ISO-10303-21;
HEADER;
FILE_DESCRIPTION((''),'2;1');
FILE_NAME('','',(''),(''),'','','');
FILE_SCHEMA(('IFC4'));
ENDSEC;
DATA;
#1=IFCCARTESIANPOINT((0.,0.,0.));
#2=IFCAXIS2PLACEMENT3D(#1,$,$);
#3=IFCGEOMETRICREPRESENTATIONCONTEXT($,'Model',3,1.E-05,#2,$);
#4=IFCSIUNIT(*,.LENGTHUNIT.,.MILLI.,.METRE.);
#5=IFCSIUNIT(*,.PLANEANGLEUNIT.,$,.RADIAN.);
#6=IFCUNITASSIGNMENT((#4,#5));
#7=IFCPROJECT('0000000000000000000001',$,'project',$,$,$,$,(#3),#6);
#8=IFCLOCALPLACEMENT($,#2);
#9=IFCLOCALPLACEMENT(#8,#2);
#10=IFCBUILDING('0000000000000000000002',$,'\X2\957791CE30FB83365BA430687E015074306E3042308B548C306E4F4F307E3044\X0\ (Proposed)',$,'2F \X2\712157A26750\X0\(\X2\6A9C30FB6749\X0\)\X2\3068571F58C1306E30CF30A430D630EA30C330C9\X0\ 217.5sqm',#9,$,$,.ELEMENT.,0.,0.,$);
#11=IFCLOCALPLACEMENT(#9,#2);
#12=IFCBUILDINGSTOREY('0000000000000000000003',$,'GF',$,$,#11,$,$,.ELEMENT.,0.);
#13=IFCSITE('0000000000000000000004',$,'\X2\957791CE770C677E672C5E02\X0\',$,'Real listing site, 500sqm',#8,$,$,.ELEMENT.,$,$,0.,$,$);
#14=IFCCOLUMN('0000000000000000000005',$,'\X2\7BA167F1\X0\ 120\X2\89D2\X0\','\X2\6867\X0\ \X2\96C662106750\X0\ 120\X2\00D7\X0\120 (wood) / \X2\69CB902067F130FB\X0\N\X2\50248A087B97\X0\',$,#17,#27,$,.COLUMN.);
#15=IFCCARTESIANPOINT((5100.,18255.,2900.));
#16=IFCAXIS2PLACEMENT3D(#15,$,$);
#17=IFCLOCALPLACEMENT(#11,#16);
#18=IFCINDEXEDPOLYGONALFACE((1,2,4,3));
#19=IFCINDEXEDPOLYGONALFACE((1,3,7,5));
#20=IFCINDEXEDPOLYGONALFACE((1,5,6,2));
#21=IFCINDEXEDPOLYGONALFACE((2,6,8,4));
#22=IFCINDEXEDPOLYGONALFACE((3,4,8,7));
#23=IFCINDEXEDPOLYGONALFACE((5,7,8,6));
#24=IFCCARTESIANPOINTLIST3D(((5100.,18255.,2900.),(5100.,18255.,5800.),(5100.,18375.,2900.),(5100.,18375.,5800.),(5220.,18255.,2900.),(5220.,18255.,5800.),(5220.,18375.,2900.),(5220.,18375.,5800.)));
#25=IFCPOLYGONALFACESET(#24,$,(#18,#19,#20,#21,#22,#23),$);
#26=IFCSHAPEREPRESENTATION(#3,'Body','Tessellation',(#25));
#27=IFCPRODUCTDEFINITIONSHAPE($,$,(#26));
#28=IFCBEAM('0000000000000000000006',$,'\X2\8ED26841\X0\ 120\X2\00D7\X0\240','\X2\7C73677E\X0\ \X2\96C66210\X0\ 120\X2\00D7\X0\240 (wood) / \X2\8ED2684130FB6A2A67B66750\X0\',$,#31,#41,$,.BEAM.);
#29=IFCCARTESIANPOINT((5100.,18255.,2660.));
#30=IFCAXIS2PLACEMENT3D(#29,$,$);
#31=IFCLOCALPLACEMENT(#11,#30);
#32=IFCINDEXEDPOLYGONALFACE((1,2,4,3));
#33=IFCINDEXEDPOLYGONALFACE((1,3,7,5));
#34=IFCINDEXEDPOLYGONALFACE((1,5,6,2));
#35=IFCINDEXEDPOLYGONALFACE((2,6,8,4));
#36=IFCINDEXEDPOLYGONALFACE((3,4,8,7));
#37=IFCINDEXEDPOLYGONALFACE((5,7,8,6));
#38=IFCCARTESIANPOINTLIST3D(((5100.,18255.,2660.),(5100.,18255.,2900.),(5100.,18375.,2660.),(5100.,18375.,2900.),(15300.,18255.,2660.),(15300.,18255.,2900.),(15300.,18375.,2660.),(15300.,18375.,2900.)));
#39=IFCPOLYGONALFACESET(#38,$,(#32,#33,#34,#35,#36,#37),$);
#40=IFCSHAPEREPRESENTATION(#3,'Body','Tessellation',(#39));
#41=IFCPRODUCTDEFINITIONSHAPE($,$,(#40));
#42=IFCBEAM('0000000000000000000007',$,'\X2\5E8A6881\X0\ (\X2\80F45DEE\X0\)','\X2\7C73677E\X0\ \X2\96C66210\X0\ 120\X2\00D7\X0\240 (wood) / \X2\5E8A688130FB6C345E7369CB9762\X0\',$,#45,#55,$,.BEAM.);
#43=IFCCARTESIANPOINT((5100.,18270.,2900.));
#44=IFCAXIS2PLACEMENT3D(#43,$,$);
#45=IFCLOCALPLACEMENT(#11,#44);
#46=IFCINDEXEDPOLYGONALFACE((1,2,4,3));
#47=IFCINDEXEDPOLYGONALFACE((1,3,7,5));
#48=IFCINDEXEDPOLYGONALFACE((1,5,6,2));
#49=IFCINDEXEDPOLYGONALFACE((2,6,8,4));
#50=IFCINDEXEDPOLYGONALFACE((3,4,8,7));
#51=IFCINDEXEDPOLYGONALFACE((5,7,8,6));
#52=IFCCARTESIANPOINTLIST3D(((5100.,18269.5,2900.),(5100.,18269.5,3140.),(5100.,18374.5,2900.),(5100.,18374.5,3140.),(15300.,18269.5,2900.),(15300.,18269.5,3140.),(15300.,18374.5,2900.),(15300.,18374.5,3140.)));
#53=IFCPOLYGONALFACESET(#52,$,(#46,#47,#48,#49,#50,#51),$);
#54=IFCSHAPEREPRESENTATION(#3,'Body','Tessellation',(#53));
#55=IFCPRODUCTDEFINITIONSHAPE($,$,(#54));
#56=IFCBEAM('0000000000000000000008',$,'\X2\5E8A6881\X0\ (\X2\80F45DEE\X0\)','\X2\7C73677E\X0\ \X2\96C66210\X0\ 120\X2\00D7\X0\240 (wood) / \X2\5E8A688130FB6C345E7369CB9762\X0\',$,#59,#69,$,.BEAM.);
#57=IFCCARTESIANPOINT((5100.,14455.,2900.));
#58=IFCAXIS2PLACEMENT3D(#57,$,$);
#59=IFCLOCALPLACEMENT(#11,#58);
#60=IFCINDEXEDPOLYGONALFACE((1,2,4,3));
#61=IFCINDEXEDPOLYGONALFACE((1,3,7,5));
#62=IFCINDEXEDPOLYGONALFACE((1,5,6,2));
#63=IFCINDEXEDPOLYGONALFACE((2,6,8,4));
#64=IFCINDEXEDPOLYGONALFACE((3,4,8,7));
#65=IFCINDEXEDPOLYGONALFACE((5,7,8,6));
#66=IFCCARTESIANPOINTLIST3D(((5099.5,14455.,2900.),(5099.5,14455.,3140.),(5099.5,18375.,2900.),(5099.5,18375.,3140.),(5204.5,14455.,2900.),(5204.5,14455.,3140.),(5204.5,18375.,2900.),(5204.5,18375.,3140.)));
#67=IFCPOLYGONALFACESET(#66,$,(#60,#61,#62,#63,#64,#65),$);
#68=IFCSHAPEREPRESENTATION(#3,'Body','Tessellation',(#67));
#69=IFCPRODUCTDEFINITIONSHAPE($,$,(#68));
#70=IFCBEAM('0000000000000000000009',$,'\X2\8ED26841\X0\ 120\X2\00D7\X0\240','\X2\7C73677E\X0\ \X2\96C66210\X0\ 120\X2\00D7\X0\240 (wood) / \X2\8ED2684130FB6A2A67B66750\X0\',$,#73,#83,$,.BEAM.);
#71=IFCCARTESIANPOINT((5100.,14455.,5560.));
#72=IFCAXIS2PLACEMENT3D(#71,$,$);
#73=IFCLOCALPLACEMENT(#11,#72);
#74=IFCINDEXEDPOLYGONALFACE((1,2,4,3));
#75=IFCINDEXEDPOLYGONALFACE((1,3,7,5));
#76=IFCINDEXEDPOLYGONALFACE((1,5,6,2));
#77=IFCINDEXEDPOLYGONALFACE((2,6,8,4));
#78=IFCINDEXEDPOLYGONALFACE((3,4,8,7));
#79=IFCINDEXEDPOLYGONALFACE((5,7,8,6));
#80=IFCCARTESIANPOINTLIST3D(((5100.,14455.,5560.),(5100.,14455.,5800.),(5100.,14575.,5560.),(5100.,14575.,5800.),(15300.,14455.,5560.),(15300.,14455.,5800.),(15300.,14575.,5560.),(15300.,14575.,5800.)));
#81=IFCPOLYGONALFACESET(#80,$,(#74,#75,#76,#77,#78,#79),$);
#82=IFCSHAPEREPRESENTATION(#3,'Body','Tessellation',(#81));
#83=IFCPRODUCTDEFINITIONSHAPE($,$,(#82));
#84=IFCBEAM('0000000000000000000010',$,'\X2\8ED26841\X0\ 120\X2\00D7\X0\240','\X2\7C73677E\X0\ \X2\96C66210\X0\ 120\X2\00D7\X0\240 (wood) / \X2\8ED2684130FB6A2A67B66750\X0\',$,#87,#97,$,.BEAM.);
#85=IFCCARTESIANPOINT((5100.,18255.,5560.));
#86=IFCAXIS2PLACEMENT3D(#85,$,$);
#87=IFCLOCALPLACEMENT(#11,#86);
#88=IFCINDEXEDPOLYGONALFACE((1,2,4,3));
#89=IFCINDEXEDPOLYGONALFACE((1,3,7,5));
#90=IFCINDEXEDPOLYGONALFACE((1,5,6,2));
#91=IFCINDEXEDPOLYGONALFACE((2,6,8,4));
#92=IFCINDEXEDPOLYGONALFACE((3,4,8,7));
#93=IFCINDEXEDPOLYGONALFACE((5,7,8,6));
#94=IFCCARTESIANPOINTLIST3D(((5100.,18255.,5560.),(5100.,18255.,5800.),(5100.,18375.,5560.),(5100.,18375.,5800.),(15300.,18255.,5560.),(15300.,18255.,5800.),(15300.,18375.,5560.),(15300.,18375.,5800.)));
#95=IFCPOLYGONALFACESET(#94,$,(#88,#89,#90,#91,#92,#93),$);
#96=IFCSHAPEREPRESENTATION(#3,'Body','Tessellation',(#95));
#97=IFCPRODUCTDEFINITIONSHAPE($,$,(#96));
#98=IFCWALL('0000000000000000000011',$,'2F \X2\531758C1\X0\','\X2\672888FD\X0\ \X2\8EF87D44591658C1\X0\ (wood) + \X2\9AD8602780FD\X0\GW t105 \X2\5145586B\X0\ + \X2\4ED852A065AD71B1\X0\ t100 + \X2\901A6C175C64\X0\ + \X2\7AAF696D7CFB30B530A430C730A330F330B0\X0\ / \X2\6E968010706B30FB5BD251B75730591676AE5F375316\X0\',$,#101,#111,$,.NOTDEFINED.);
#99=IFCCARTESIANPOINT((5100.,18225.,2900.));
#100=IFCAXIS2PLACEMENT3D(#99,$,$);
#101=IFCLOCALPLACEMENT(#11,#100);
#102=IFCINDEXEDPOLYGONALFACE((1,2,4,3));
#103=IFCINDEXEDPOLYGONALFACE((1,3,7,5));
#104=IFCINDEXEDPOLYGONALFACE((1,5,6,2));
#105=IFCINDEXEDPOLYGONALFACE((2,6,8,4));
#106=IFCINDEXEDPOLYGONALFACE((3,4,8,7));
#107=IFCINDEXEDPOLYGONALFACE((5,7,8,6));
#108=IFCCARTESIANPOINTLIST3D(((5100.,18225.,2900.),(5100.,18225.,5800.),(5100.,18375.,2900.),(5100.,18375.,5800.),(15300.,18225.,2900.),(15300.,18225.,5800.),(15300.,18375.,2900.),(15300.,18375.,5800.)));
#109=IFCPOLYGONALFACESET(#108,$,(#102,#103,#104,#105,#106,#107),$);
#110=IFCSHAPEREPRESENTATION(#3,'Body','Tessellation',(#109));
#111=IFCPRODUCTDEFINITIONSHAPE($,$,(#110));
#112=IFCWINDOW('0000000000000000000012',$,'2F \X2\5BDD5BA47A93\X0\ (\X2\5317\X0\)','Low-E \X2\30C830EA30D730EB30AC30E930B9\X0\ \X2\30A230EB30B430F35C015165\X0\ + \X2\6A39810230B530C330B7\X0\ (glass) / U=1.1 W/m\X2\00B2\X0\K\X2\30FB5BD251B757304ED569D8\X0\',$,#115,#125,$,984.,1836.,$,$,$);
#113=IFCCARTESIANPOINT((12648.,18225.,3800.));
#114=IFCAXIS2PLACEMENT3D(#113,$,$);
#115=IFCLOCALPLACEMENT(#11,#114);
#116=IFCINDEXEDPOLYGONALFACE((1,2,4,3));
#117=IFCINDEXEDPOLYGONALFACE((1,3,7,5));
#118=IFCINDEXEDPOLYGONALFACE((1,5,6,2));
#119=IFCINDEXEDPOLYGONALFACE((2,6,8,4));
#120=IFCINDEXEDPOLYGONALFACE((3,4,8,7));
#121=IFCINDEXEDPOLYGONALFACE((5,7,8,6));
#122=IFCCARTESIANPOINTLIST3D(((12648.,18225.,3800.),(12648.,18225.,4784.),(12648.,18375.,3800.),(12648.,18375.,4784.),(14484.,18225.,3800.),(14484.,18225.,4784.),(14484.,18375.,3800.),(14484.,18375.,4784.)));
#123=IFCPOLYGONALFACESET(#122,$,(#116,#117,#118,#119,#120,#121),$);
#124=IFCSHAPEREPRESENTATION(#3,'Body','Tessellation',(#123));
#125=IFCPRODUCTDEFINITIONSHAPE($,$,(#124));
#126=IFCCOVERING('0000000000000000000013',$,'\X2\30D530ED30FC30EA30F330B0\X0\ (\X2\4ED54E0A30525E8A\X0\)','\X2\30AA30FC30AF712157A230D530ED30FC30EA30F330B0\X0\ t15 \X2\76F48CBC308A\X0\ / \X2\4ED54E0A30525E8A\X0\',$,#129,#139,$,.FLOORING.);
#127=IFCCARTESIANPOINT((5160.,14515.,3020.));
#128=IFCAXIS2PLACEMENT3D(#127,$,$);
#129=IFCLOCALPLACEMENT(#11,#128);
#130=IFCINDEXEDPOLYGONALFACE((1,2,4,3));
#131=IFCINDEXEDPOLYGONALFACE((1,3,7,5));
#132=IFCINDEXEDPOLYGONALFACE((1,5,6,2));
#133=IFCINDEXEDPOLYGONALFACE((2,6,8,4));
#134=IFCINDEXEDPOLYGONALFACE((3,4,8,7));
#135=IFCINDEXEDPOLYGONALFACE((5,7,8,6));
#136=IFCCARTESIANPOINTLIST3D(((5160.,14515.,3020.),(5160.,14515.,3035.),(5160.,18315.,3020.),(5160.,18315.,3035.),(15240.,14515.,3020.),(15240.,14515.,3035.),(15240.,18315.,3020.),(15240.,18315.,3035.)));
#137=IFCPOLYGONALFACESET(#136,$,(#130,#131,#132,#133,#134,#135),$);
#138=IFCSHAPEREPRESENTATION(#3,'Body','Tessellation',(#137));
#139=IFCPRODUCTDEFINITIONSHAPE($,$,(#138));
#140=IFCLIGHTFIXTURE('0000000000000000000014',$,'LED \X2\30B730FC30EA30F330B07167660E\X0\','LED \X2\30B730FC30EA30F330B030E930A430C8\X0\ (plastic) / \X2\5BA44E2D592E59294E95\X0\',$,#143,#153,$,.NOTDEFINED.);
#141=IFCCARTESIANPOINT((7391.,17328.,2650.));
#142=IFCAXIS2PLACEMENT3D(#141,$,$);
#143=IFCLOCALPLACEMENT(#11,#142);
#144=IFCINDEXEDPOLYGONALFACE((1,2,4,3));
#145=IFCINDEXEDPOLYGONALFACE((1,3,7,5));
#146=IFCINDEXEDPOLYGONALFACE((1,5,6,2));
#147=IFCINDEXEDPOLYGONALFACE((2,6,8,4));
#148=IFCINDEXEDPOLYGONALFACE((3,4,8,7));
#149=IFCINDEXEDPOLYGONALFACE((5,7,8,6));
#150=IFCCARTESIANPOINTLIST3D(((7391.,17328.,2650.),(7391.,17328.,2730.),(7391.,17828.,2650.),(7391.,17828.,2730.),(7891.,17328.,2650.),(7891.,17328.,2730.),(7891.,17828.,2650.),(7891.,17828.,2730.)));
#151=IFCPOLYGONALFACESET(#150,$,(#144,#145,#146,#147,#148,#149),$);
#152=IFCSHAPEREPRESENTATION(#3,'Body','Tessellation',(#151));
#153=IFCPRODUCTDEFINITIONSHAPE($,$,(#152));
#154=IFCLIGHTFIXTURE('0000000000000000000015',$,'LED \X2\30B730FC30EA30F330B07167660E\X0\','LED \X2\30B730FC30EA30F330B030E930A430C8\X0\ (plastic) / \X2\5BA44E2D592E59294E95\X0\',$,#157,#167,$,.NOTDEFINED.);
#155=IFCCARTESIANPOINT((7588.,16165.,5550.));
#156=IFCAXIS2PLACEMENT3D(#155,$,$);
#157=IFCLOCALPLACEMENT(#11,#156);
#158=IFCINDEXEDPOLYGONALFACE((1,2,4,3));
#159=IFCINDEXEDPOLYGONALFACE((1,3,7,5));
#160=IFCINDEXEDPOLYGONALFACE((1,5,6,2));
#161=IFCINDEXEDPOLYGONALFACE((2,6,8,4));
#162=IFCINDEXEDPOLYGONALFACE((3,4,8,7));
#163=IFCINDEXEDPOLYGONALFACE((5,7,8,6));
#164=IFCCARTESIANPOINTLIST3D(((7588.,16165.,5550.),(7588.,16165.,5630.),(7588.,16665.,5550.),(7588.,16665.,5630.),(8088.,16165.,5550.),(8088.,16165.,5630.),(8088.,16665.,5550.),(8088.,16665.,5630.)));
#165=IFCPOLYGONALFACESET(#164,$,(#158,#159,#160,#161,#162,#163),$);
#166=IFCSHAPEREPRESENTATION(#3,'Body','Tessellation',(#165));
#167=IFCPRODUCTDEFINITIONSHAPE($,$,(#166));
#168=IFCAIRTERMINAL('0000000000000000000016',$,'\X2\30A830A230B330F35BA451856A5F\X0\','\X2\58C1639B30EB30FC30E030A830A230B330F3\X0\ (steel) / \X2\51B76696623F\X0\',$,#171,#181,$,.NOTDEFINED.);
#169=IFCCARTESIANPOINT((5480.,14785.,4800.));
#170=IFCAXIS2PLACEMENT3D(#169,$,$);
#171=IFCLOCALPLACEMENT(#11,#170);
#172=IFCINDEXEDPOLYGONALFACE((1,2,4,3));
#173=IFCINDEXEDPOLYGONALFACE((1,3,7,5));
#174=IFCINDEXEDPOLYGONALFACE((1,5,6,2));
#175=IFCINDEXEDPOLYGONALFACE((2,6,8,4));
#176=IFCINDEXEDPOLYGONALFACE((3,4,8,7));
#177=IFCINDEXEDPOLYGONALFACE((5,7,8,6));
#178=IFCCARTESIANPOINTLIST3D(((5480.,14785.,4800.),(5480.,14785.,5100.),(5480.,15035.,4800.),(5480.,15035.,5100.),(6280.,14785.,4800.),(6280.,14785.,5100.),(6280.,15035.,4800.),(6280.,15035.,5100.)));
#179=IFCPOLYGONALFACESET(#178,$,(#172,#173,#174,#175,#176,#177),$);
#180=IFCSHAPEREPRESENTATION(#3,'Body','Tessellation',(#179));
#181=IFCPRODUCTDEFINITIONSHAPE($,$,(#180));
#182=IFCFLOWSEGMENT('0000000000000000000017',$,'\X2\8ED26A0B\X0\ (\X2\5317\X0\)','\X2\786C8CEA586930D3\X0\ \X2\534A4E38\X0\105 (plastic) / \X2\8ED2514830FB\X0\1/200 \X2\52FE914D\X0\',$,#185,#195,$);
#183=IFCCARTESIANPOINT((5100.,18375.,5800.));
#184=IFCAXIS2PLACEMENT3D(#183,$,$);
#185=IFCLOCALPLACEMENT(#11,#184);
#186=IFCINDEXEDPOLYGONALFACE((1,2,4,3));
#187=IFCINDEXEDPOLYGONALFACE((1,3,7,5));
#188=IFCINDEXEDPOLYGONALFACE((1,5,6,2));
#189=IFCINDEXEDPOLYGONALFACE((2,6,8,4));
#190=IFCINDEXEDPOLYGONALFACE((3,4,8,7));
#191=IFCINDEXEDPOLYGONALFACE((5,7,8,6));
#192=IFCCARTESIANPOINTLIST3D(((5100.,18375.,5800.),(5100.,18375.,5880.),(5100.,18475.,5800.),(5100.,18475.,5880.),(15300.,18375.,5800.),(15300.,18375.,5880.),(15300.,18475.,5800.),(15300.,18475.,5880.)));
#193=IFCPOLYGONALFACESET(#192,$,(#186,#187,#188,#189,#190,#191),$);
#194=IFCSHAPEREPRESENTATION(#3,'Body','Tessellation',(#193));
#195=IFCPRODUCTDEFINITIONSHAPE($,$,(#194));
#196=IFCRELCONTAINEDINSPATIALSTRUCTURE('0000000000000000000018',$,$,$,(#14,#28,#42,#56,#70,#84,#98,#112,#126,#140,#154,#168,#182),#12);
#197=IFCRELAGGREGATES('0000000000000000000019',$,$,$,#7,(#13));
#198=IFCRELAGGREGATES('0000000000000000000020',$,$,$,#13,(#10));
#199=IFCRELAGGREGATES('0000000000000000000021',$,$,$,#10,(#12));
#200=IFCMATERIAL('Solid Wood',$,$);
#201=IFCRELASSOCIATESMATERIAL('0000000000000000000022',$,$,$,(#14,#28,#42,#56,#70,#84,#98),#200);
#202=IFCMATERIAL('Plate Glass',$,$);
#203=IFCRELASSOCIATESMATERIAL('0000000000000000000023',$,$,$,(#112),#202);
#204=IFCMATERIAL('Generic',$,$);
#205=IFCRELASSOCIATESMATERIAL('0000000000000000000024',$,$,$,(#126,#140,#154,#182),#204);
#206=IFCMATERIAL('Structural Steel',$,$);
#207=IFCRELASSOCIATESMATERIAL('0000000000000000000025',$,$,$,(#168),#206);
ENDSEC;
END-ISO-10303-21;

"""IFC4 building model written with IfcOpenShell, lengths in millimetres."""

from ifc_helpers import new_model, si_unit, frame, frame_2d, origin, place, context, project, spatial, rectangle, extrude, material, element, fill, save


model = new_model("IFC4")

# Units and contexts
model_context = context("Model", 3, precision=1e-05, world=origin())
ifc_project = project(units=[si_unit("LENGTHUNIT", "METRE", prefix="MILLI"), si_unit("PLANEANGLEUNIT", "RADIAN")], contexts=[model_context])

# Site, building, storey
site_placement = place(None, origin())
site = spatial("IfcSite", under=ifc_project, at=site_placement, Name="長野県松本市", ObjectType="Real listing site, 500sqm", CompositionType="ELEMENT", RefElevation=0.0)
building_placement = place(site_placement, origin())
building = spatial("IfcBuilding", under=site, at=building_placement, Name="長野・茶室と縁側のある和の住まい (Proposed)", ObjectType="2F 無垢材(檜・杉)と土壁のハイブリッド 217.5sqm", CompositionType="ELEMENT", ElevationOfRefHeight=0.0, ElevationOfTerrain=0.0)
storey_placement = place(building_placement, origin())
storey = spatial("IfcBuildingStorey", under=building, at=storey_placement, Name="GF", CompositionType="ELEMENT", Elevation=0.0)

# Column
ifc_material_1 = material(Name="Solid Wood")
column_1_placement = place(storey_placement, frame((5100.0, 18255.0, 2900.0)))
element("IfcColumn", 1, at=column_1_placement, inside=storey, material=ifc_material_1, Name="管柱 120角", Description="桧 集成材 120×120 (wood) / 構造柱・N値計算", PredefinedType="COLUMN", context=model_context, shape_type="SweptSolid", body=[
    extrude(rectangle(XDim=120.0, YDim=120.0, at=frame_2d((60.0, 60.0))), frame((5100.0, 18255.0, 2900.0)), (0.0, 0.0, 1.0), 2900.0),
])

# Beams
beam_1_placement = place(storey_placement, frame((5100.0, 18255.0, 2660.0)))
element("IfcBeam", 2, at=beam_1_placement, inside=storey, material=ifc_material_1, Name="軒桁 120×240", Description="米松 集成 120×240 (wood) / 軒桁・横架材", PredefinedType="BEAM", context=model_context, shape_type="SweptSolid", body=[
    extrude(rectangle(XDim=10200.0, YDim=120.0, at=frame_2d((5100.0, 60.0))), frame((5100.0, 18255.0, 2660.0)), (0.0, 0.0, 1.0), 240.0),
])
beam_2_placement = place(storey_placement, frame((5100.0, 18270.0, 2900.0)))
element("IfcBeam", 3, at=beam_2_placement, inside=storey, material=ifc_material_1, Name="床梁 (胴差)", Description="米松 集成 120×240 (wood) / 床梁・水平構面", PredefinedType="BEAM", context=model_context, shape_type="SweptSolid", body=[
    extrude(rectangle(XDim=10200.0, YDim=105.0, at=frame_2d((5100.0, 52.0))), frame((5100.0, 18270.0, 2900.0)), (0.0, 0.0, 1.0), 240.0),
])
beam_3_placement = place(storey_placement, frame((5100.0, 14455.0, 2900.0)))
element("IfcBeam", 4, at=beam_3_placement, inside=storey, material=ifc_material_1, Name="床梁 (胴差)", Description="米松 集成 120×240 (wood) / 床梁・水平構面", PredefinedType="BEAM", context=model_context, shape_type="SweptSolid", body=[
    extrude(rectangle(XDim=105.0, YDim=3920.0, at=frame_2d((52.0, 1960.0))), frame((5100.0, 14455.0, 2900.0)), (0.0, 0.0, 1.0), 240.0),
])
beam_4_placement = place(storey_placement, frame((5100.0, 14455.0, 5560.0)))
element("IfcBeam", 5, at=beam_4_placement, inside=storey, material=ifc_material_1, Name="軒桁 120×240", Description="米松 集成 120×240 (wood) / 軒桁・横架材", PredefinedType="BEAM", context=model_context, shape_type="SweptSolid", body=[
    extrude(rectangle(XDim=10200.0, YDim=120.0, at=frame_2d((5100.0, 60.0))), frame((5100.0, 14455.0, 5560.0)), (0.0, 0.0, 1.0), 240.0),
])
beam_5_placement = place(storey_placement, frame((5100.0, 18255.0, 5560.0)))
element("IfcBeam", 6, at=beam_5_placement, inside=storey, material=ifc_material_1, Name="軒桁 120×240", Description="米松 集成 120×240 (wood) / 軒桁・横架材", PredefinedType="BEAM", context=model_context, shape_type="SweptSolid", body=[
    extrude(rectangle(XDim=10200.0, YDim=120.0, at=frame_2d((5100.0, 60.0))), frame((5100.0, 18255.0, 5560.0)), (0.0, 0.0, 1.0), 240.0),
])

# Wall, opening, window
wall_placement = place(storey_placement, frame((5100.0, 18225.0, 2900.0)))
wall = element("IfcWall", 7, at=wall_placement, inside=storey, material=ifc_material_1, Name="2F 北壁", Description="木製 軸組外壁 (wood) + 高性能GW t105 充填 + 付加断熱 t100 + 通気層 + 窯業系サイディング / 準耐火・寒冷地外皮強化", PredefinedType="NOTDEFINED", context=model_context, shape_type="SweptSolid", body=[
    extrude(rectangle(XDim=10200.0, YDim=150.0, at=frame_2d((5100.0, 75.0))), frame((5100.0, 18225.0, 2900.0)), (0.0, 0.0, 1.0), 2900.0),
])
opening_placement = place(storey_placement, frame((12648.0, 18225.0, 3800.0)))
opening = element("IfcOpeningElement", 8, at=opening_placement, cuts=wall, PredefinedType="NOTDEFINED", context=model_context, shape_type="SweptSolid", body=[
    extrude(rectangle(XDim=1836.0, YDim=150.0, at=frame_2d((918.0, 75.0))), frame((12648.0, 18225.0, 3800.0)), (0.0, 0.0, 1.0), 984.0),
])
ifc_material_2 = material(Name="Plate Glass")
window_placement = place(storey_placement, frame((12648.0, 18225.0, 3800.0)))
window = element("IfcWindow", 9, at=window_placement, inside=storey, material=ifc_material_2, Name="2F 寝室窓 (北)", Description="Low-E トリプルガラス アルゴン封入 + 樹脂サッシ (glass) / U=1.1 W/m²K・寒冷地仕様", OverallHeight=984.0, OverallWidth=1836.0, context=model_context, shape_type="SweptSolid", body=[
    extrude(rectangle(XDim=1836.0, YDim=150.0, at=frame_2d((918.0, 75.0))), frame((12648.0, 18225.0, 3800.0)), (0.0, 0.0, 1.0), 984.0),
])
fill(opening, window)

# Covering
ifc_material_3 = material(Name="Generic")
covering_placement = place(storey_placement, frame((5160.0, 14515.0, 3020.0)))
element("IfcCovering", 10, at=covering_placement, inside=storey, material=ifc_material_3, Name="フローリング (仕上げ床)", Description="オーク無垢フローリング t15 直貼り / 仕上げ床", PredefinedType="FLOORING", context=model_context, shape_type="SweptSolid", body=[
    extrude(rectangle(XDim=10080.0, YDim=3800.0, at=frame_2d((5040.0, 1900.0))), frame((5160.0, 14515.0, 3020.0)), (0.0, 0.0, 1.0), 15.0),
])

# Light fixtures
light_fixture_1_placement = place(storey_placement, frame((7391.0, 17328.0, 2650.0)))
element("IfcLightFixture", 11, at=light_fixture_1_placement, inside=storey, material=ifc_material_3, Name="LED シーリング照明", Description="LED シーリングライト (plastic) / 室中央天井", PredefinedType="NOTDEFINED", context=model_context, shape_type="SweptSolid", body=[
    extrude(rectangle(XDim=500.0, YDim=500.0, at=frame_2d((250.0, 250.0))), frame((7391.0, 17328.0, 2650.0)), (0.0, 0.0, 1.0), 80.0),
])
light_fixture_2_placement = place(storey_placement, frame((7588.0, 16165.0, 5550.0)))
element("IfcLightFixture", 12, at=light_fixture_2_placement, inside=storey, material=ifc_material_3, Name="LED シーリング照明", Description="LED シーリングライト (plastic) / 室中央天井", PredefinedType="NOTDEFINED", context=model_context, shape_type="SweptSolid", body=[
    extrude(rectangle(XDim=500.0, YDim=500.0, at=frame_2d((250.0, 250.0))), frame((7588.0, 16165.0, 5550.0)), (0.0, 0.0, 1.0), 80.0),
])

# Air terminal
ifc_material_4 = material(Name="Structural Steel")
air_terminal_placement = place(storey_placement, frame((5480.0, 14785.0, 4800.0)))
element("IfcAirTerminal", 13, at=air_terminal_placement, inside=storey, material=ifc_material_4, Name="エアコン室内機", Description="壁掛ルームエアコン (steel) / 冷暖房", PredefinedType="NOTDEFINED", context=model_context, shape_type="SweptSolid", body=[
    extrude(rectangle(XDim=800.0, YDim=250.0, at=frame_2d((400.0, 125.0))), frame((5480.0, 14785.0, 4800.0)), (0.0, 0.0, 1.0), 300.0),
])

# Flow segment
flow_segment_placement = place(storey_placement, frame((5100.0, 18375.0, 5800.0)))
element("IfcFlowSegment", 14, at=flow_segment_placement, inside=storey, material=ifc_material_3, Name="軒樋 (北)", Description="硬質塩ビ 半丸105 (plastic) / 軒先・1/200 勾配", context=model_context, shape_type="SweptSolid", body=[
    extrude(rectangle(XDim=10200.0, YDim=100.0, at=frame_2d((5100.0, 50.0))), frame((5100.0, 18375.0, 5800.0)), (0.0, 0.0, 1.0), 80.0),
])

save(model, "model.ifc")
